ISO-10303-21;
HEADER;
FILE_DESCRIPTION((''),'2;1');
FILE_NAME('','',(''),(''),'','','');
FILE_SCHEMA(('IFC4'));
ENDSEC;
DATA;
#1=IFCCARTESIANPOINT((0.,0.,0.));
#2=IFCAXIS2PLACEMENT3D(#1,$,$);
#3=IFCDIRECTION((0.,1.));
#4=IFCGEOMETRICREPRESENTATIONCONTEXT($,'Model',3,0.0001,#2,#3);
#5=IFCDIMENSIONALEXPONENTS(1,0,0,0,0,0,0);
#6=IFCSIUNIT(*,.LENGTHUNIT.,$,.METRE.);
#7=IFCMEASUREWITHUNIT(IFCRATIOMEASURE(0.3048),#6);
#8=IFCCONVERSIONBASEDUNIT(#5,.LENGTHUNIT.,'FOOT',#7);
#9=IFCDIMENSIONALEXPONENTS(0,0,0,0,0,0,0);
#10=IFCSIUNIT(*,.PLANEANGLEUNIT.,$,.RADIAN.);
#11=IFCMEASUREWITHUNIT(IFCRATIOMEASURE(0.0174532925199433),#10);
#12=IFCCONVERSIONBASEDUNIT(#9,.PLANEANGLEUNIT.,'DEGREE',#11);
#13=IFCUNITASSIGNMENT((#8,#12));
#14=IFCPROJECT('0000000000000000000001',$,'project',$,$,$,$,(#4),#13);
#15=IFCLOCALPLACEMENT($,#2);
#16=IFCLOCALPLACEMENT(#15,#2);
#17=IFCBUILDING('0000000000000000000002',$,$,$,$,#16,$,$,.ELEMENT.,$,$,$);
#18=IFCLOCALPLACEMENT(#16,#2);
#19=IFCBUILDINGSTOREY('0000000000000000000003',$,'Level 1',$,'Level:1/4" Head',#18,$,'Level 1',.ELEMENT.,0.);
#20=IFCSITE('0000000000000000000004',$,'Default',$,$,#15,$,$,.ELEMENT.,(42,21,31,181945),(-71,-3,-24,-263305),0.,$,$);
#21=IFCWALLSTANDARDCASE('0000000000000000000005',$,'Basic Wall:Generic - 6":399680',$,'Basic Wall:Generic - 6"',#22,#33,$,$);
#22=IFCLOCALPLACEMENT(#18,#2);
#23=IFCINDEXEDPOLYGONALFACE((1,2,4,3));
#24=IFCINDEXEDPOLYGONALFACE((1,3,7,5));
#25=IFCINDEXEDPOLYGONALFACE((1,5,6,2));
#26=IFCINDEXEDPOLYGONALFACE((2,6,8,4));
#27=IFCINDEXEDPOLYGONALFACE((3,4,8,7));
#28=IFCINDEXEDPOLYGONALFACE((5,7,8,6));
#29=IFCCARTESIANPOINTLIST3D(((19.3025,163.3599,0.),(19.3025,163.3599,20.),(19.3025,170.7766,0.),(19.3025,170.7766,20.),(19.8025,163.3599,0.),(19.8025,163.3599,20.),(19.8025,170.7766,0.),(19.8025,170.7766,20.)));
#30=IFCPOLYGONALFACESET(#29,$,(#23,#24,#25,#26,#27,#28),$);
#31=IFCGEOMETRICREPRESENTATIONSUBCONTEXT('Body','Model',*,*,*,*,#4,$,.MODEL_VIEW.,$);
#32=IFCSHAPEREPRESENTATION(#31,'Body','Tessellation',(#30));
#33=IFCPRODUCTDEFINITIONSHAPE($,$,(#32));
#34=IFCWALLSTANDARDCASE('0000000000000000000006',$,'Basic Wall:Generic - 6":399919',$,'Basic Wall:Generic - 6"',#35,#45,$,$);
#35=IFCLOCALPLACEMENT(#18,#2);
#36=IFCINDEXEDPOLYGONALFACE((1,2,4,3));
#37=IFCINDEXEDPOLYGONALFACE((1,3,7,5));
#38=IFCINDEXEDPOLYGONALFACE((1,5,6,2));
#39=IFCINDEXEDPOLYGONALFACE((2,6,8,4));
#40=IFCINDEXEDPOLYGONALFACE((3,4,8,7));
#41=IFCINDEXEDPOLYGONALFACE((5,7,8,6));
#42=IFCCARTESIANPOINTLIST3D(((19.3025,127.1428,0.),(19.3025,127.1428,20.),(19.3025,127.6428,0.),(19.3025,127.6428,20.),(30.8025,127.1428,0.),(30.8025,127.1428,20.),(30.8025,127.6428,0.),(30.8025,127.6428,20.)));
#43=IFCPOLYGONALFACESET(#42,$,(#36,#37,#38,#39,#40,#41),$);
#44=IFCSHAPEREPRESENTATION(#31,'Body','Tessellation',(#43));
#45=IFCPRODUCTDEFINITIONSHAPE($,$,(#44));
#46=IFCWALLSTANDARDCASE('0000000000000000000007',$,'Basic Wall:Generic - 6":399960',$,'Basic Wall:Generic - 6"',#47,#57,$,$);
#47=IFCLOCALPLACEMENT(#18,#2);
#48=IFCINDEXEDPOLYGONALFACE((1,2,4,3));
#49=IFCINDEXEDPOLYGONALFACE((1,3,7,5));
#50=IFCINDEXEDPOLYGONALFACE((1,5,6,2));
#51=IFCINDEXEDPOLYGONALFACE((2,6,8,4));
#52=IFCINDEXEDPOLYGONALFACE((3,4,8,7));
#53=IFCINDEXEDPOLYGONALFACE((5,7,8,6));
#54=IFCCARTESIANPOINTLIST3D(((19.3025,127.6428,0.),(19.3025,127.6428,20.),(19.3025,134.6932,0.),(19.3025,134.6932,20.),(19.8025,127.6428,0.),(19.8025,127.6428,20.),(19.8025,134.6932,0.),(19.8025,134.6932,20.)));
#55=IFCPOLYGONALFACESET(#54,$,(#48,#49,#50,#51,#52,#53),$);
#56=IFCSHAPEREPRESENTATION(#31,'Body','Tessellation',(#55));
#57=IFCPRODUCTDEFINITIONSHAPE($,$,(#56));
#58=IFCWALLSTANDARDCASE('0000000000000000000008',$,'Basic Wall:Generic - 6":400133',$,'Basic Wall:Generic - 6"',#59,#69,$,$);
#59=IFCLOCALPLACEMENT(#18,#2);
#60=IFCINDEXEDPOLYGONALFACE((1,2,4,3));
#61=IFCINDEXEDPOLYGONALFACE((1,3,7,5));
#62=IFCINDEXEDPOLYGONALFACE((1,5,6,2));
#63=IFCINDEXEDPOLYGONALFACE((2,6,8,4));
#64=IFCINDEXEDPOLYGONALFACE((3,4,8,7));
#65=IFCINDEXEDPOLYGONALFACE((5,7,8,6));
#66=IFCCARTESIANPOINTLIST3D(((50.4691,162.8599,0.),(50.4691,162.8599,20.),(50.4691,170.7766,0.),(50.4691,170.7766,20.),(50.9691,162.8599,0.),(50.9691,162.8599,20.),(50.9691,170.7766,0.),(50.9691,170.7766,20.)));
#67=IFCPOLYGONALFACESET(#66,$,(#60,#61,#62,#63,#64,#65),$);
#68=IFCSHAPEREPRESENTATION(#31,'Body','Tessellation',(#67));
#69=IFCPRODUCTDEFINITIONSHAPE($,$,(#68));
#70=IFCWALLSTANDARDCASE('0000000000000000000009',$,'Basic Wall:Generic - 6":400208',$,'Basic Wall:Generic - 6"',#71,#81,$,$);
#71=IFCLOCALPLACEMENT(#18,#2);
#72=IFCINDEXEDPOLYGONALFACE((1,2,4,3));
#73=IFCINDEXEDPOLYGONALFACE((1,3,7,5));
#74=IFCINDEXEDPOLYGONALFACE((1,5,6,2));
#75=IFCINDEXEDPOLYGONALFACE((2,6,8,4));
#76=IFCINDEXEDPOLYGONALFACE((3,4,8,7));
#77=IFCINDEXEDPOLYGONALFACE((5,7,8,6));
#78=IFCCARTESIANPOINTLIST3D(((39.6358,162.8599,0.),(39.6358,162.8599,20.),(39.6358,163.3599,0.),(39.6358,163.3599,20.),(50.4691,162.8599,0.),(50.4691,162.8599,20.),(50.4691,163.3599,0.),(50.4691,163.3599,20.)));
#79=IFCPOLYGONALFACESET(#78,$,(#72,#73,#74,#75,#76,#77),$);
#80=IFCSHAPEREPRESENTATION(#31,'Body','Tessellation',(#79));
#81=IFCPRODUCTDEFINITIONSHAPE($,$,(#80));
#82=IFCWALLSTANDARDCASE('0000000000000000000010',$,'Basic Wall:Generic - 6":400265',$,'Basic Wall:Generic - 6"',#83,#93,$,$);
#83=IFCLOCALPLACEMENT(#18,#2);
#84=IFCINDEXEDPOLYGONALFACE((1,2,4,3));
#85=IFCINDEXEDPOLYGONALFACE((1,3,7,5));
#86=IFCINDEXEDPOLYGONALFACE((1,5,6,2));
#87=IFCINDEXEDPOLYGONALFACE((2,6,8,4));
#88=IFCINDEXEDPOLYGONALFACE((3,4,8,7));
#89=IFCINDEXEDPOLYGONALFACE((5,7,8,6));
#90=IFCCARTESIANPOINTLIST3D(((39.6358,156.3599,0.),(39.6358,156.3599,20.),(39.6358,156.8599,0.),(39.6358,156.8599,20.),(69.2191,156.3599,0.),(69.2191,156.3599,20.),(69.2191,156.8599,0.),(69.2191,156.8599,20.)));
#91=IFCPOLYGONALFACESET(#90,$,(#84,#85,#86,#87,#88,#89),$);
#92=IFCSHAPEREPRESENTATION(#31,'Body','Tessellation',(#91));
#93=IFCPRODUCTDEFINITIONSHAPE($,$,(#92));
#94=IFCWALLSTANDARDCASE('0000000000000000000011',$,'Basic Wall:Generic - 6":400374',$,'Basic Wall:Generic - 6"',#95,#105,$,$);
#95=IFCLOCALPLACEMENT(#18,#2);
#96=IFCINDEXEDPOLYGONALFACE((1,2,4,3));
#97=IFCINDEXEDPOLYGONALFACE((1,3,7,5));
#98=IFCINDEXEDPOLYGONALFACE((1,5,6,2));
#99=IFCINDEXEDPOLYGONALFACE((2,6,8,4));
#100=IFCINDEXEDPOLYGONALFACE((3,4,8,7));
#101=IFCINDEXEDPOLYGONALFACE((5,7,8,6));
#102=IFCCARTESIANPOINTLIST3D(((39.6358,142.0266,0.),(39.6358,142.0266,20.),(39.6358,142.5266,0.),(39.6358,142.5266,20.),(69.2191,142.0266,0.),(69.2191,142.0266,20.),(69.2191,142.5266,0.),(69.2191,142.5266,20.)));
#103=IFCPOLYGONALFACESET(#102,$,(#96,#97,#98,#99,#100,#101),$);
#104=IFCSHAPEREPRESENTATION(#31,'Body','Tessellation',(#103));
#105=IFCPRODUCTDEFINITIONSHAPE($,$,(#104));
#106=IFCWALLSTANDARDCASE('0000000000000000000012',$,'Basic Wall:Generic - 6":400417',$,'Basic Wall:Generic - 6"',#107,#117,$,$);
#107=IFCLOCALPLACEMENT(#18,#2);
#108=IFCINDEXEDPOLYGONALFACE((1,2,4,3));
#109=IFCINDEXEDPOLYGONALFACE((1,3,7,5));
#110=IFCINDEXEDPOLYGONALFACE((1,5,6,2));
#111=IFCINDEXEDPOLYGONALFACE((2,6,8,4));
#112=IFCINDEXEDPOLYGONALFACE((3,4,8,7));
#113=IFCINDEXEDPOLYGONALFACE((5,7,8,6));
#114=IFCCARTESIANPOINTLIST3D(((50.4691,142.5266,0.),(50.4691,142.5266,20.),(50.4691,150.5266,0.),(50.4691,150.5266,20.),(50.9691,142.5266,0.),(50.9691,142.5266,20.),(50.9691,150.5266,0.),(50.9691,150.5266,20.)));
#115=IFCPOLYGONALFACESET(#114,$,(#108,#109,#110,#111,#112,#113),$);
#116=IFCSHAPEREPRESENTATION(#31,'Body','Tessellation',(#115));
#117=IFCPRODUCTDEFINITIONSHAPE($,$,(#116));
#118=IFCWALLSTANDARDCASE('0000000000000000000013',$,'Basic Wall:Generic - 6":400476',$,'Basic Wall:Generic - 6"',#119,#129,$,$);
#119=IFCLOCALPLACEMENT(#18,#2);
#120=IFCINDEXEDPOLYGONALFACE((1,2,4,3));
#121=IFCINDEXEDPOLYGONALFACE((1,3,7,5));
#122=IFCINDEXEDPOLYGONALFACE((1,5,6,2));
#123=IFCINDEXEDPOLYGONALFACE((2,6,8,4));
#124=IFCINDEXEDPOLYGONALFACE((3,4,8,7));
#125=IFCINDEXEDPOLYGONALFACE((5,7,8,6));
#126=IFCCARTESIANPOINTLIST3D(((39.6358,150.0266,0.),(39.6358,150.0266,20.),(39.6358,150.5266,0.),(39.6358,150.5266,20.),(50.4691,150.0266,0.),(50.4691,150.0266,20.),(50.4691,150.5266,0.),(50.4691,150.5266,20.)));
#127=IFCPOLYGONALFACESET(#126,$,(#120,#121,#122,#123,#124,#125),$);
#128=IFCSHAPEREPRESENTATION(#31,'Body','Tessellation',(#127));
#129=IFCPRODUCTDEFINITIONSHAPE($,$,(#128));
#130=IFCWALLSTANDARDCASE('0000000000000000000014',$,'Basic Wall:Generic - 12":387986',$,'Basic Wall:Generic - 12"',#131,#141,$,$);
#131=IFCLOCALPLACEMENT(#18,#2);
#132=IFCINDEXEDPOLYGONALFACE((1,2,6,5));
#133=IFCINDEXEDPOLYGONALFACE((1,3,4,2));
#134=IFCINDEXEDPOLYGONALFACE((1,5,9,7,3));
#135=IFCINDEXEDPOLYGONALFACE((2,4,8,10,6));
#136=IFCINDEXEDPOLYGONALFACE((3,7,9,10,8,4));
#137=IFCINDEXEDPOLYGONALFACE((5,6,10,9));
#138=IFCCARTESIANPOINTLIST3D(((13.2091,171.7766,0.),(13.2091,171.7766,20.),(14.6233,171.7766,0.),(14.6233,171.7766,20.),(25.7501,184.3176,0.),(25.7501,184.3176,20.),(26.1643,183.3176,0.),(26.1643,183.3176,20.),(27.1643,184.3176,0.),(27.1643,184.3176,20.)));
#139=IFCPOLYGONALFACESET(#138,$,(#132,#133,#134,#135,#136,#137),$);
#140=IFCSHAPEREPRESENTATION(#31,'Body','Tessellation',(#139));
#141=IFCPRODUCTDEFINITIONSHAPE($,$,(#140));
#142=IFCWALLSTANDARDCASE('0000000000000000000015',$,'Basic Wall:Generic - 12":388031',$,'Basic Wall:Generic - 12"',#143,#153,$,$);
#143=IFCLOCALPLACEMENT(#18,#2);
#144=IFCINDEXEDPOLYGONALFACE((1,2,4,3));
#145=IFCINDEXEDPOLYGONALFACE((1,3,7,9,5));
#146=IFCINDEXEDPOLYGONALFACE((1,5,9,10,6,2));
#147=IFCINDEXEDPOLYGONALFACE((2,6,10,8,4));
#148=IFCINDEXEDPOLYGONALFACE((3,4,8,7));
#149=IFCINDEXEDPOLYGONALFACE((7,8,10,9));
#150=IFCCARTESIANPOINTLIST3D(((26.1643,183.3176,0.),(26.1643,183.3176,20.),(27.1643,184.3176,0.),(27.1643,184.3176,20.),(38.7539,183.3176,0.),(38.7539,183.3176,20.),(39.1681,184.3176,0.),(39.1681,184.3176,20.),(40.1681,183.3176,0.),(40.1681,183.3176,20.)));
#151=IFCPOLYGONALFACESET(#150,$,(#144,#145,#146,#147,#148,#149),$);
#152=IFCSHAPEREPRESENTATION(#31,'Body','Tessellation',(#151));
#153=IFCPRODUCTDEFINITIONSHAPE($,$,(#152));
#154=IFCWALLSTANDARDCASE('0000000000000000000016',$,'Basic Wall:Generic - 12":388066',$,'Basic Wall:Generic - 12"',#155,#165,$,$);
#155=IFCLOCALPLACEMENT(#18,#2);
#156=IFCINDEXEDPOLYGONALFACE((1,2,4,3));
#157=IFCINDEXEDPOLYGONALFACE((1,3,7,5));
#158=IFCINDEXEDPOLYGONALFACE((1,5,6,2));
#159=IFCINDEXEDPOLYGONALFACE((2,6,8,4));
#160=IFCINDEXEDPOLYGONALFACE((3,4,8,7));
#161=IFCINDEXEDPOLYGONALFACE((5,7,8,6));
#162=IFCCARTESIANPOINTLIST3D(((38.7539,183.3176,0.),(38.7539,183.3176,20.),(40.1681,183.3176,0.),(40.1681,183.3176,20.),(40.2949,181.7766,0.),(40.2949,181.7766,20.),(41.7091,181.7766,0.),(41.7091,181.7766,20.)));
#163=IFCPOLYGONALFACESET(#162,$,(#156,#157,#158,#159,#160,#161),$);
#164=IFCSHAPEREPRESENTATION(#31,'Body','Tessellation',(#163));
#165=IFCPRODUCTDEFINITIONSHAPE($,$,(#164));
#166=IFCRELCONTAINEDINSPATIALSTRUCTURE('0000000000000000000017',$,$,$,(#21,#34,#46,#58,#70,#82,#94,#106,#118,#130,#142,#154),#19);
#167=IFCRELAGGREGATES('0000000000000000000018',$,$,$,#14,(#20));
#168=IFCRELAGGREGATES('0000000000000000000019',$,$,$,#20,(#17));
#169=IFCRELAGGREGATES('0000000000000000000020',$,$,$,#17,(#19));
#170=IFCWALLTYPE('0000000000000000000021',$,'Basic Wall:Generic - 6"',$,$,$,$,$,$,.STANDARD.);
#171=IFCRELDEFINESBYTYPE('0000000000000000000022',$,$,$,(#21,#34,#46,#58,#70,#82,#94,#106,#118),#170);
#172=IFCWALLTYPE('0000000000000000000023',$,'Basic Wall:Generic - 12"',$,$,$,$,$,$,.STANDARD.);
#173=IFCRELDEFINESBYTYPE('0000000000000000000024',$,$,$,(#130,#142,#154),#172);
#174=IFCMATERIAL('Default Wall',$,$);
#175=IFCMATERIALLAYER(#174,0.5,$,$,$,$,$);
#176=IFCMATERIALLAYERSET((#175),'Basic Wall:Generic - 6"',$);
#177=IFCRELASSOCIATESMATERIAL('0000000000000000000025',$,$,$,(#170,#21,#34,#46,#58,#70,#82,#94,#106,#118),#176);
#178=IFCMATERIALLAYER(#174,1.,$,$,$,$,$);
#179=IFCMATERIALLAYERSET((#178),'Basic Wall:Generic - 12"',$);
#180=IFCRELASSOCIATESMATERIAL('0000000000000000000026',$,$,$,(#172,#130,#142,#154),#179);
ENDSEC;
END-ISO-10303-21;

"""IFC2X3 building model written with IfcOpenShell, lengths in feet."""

from ifc_helpers import new_model, entity, si_unit, converted_unit, direction, frame, frame_2d, origin, place, context, subcontext, project, spatial, polyline, rectangle, outline, extrude, material, layer, layer_set, layer_usage, type_object, element, save


model = new_model("IFC2X3")

# Units and contexts
model_context = context("Model", 3, precision=0.0001, world=origin(), true_north=direction((0.0, 1.0)))
body_context = subcontext(model_context, "Body", "Model", "MODEL_VIEW")
ifc_project = project(units=[converted_unit("LENGTHUNIT", "FOOT", entity("IfcRatioMeasure", 0.3048), si_unit("LENGTHUNIT", "METRE"), dimensions=[1, 0, 0, 0, 0, 0, 0]), converted_unit("PLANEANGLEUNIT", "DEGREE", entity("IfcRatioMeasure", 0.0174532925199433), si_unit("PLANEANGLEUNIT", "RADIAN"), dimensions=[0, 0, 0, 0, 0, 0, 0])], contexts=[model_context])

# Site, building, storey
site_placement = place(None, origin())
site = spatial("IfcSite", under=ifc_project, at=site_placement, Name="Default", CompositionType="ELEMENT", RefLatitude=(42, 21, 31, 181945), RefLongitude=(-71, -3, -24, -263305), RefElevation=0.0)
building_placement = place(site_placement, origin())
building = spatial("IfcBuilding", under=site, at=building_placement, CompositionType="ELEMENT")
storey_placement = place(building_placement, origin())
storey = spatial("IfcBuildingStorey", under=building, at=storey_placement, Name="Level 1", ObjectType="Level:1/4\" Head", LongName="Level 1", CompositionType="ELEMENT", Elevation=0.0)

# Walls
ifc_material = material(Name="Default Wall")
ifc_layer_1 = layer(ifc_material, 0.5)
ifc_layer_set_1 = layer_set([ifc_layer_1], Name="Basic Wall:Generic - 6\"")
wall_type_1 = type_object("IfcWallType", Name="Basic Wall:Generic - 6\"", PredefinedType="STANDARD", material=ifc_layer_set_1)
ifc_layer_usage_1 = layer_usage(ifc_layer_set_1, "AXIS2", "NEGATIVE", 0.25)
wall_1_placement = place(storey_placement, frame((19.5525, 163.3599, 0.0), z_axis=(0.0, 0.0, 1.0), x_axis=(0.0, 1.0, 0.0)))
element("IfcWallStandardCase", 1, at=wall_1_placement, inside=storey, type_object=wall_type_1, material=ifc_layer_usage_1, Name="Basic Wall:Generic - 6\":399680", ObjectType="Basic Wall:Generic - 6\"", context=body_context, shape_type="SweptSolid", body=[
    extrude(rectangle(XDim=7.4167, YDim=0.5, at=frame_2d((3.7083, 0.0), x_axis=(-1.0, 0.0))), origin(), (0.0, 0.0, 1.0), 20.0),
])
ifc_layer_usage_2 = layer_usage(ifc_layer_set_1, "AXIS2", "NEGATIVE", 0.25)
wall_2_placement = place(storey_placement, frame((30.8025, 127.3928, 0.0), z_axis=(0.0, 0.0, 1.0), x_axis=(-1.0, 0.0, 0.0)))
element("IfcWallStandardCase", 2, at=wall_2_placement, inside=storey, type_object=wall_type_1, material=ifc_layer_usage_2, Name="Basic Wall:Generic - 6\":399919", ObjectType="Basic Wall:Generic - 6\"", context=body_context, shape_type="SweptSolid", body=[
    extrude(rectangle(XDim=11.5, YDim=0.5, at=frame_2d((5.75, 0.0), x_axis=(-1.0, 0.0))), origin(), (0.0, 0.0, 1.0), 20.0),
])
ifc_layer_usage_3 = layer_usage(ifc_layer_set_1, "AXIS2", "NEGATIVE", 0.25)
wall_3_placement = place(storey_placement, frame((19.5525, 127.6428, 0.0), z_axis=(0.0, 0.0, 1.0), x_axis=(0.0, 1.0, 0.0)))
element("IfcWallStandardCase", 3, at=wall_3_placement, inside=storey, type_object=wall_type_1, material=ifc_layer_usage_3, Name="Basic Wall:Generic - 6\":399960", ObjectType="Basic Wall:Generic - 6\"", context=body_context, shape_type="SweptSolid", body=[
    extrude(rectangle(XDim=7.0504, YDim=0.5, at=frame_2d((3.5252, 0.0), x_axis=(-1.0, 0.0))), origin(), (0.0, 0.0, 1.0), 20.0),
])
ifc_layer_usage_4 = layer_usage(ifc_layer_set_1, "AXIS2", "NEGATIVE", 0.25)
wall_4_placement = place(storey_placement, frame((50.7191, 170.7766, 0.0), z_axis=(0.0, 0.0, 1.0), x_axis=(0.0, -1.0, 0.0)))
element("IfcWallStandardCase", 4, at=wall_4_placement, inside=storey, type_object=wall_type_1, material=ifc_layer_usage_4, Name="Basic Wall:Generic - 6\":400133", ObjectType="Basic Wall:Generic - 6\"", context=body_context, shape_type="SweptSolid", body=[
    extrude(rectangle(XDim=7.9167, YDim=0.5, at=frame_2d((3.9583, 0.0), x_axis=(-1.0, 0.0))), origin(), (0.0, 0.0, 1.0), 20.0),
])
ifc_layer_usage_5 = layer_usage(ifc_layer_set_1, "AXIS2", "NEGATIVE", 0.25)
wall_5_placement = place(storey_placement, frame((50.4691, 163.1099, 0.0), z_axis=(0.0, 0.0, 1.0), x_axis=(-1.0, 0.0, 0.0)))
element("IfcWallStandardCase", 5, at=wall_5_placement, inside=storey, type_object=wall_type_1, material=ifc_layer_usage_5, Name="Basic Wall:Generic - 6\":400208", ObjectType="Basic Wall:Generic - 6\"", context=body_context, shape_type="SweptSolid", body=[
    extrude(rectangle(XDim=10.8333, YDim=0.5, at=frame_2d((5.4167, 0.0), x_axis=(-1.0, 0.0))), origin(), (0.0, 0.0, 1.0), 20.0),
])
ifc_layer_usage_6 = layer_usage(ifc_layer_set_1, "AXIS2", "NEGATIVE", 0.25)
wall_6_placement = place(storey_placement, frame((39.6358, 156.6099, 0.0)))
element("IfcWallStandardCase", 6, at=wall_6_placement, inside=storey, type_object=wall_type_1, material=ifc_layer_usage_6, Name="Basic Wall:Generic - 6\":400265", ObjectType="Basic Wall:Generic - 6\"", context=body_context, shape_type="SweptSolid", body=[
    extrude(rectangle(XDim=29.5833, YDim=0.5, at=frame_2d((14.7917, 0.0), x_axis=(-1.0, 0.0))), origin(), (0.0, 0.0, 1.0), 20.0),
])
ifc_layer_usage_7 = layer_usage(ifc_layer_set_1, "AXIS2", "NEGATIVE", 0.25)
wall_7_placement = place(storey_placement, frame((69.2191, 142.2766, 0.0), z_axis=(0.0, 0.0, 1.0), x_axis=(-1.0, 0.0, 0.0)))
element("IfcWallStandardCase", 7, at=wall_7_placement, inside=storey, type_object=wall_type_1, material=ifc_layer_usage_7, Name="Basic Wall:Generic - 6\":400374", ObjectType="Basic Wall:Generic - 6\"", context=body_context, shape_type="SweptSolid", body=[
    extrude(rectangle(XDim=29.5833, YDim=0.5, at=frame_2d((14.7917, 0.0), x_axis=(-1.0, 0.0))), origin(), (0.0, 0.0, 1.0), 20.0),
])
ifc_layer_usage_8 = layer_usage(ifc_layer_set_1, "AXIS2", "NEGATIVE", 0.25)
wall_8_placement = place(storey_placement, frame((50.7191, 142.5266, 0.0), z_axis=(0.0, 0.0, 1.0), x_axis=(0.0, 1.0, 0.0)))
element("IfcWallStandardCase", 8, at=wall_8_placement, inside=storey, type_object=wall_type_1, material=ifc_layer_usage_8, Name="Basic Wall:Generic - 6\":400417", ObjectType="Basic Wall:Generic - 6\"", context=body_context, shape_type="SweptSolid", body=[
    extrude(rectangle(XDim=8.0, YDim=0.5, at=frame_2d((4.0, 0.0), x_axis=(-1.0, 0.0))), origin(), (0.0, 0.0, 1.0), 20.0),
])
ifc_layer_usage_9 = layer_usage(ifc_layer_set_1, "AXIS2", "NEGATIVE", 0.25)
wall_9_placement = place(storey_placement, frame((50.4691, 150.2766, 0.0), z_axis=(0.0, 0.0, 1.0), x_axis=(-1.0, 0.0, 0.0)))
element("IfcWallStandardCase", 9, at=wall_9_placement, inside=storey, type_object=wall_type_1, material=ifc_layer_usage_9, Name="Basic Wall:Generic - 6\":400476", ObjectType="Basic Wall:Generic - 6\"", context=body_context, shape_type="SweptSolid", body=[
    extrude(rectangle(XDim=10.8333, YDim=0.5, at=frame_2d((5.4167, 0.0), x_axis=(-1.0, 0.0))), origin(), (0.0, 0.0, 1.0), 20.0),
])
ifc_layer_2 = layer(ifc_material, 1.0)
ifc_layer_set_2 = layer_set([ifc_layer_2], Name="Basic Wall:Generic - 12\"")
ifc_layer_usage_10 = layer_usage(ifc_layer_set_2, "AXIS2", "NEGATIVE", 0.5)
wall_type_2 = type_object("IfcWallType", Name="Basic Wall:Generic - 12\"", PredefinedType="STANDARD", material=ifc_layer_set_2)
wall_10_placement = place(storey_placement, frame((13.5626, 171.423, 0.0), z_axis=(0.0, 0.0, 1.0), x_axis=(0.707107, 0.707107, 0.0)))
element("IfcWallStandardCase", 10, at=wall_10_placement, inside=storey, type_object=wall_type_2, material=ifc_layer_usage_10, Name="Basic Wall:Generic - 12\":387986", ObjectType="Basic Wall:Generic - 12\"", context=body_context, shape_type="SweptSolid", body=[
    extrude(outline(polyline([(18.7357, -0.5), (17.7357, 0.5), (0.0, 0.5), (1.0, -0.5), (17.3215, -0.5), (18.7357, -0.5)])), origin(), (0.0, 0.0, 1.0), 20.0),
])
ifc_layer_usage_11 = layer_usage(ifc_layer_set_2, "AXIS2", "NEGATIVE", 0.5)
wall_11_placement = place(storey_placement, frame((26.1643, 183.8176, 0.0)))
element("IfcWallStandardCase", 11, at=wall_11_placement, inside=storey, type_object=wall_type_2, material=ifc_layer_usage_11, Name="Basic Wall:Generic - 12\":388031", ObjectType="Basic Wall:Generic - 12\"", context=body_context, shape_type="SweptSolid", body=[
    extrude(outline(polyline([(14.0037, -0.5), (13.0037, 0.5), (1.0, 0.5), (0.0, -0.5), (12.5895, -0.5), (14.0037, -0.5)])), origin(), (0.0, 0.0, 1.0), 20.0),
])
ifc_layer_usage_12 = layer_usage(ifc_layer_set_2, "AXIS2", "NEGATIVE", 0.5)
wall_12_placement = place(storey_placement, frame((39.1074, 183.6712, 0.0), z_axis=(0.0, 0.0, 1.0), x_axis=(0.707107, -0.707107, 0.0)))
element("IfcWallStandardCase", 12, at=wall_12_placement, inside=storey, type_object=wall_type_2, material=ifc_layer_usage_12, Name="Basic Wall:Generic - 12\":388066", ObjectType="Basic Wall:Generic - 12\"", context=body_context, shape_type="SweptSolid", body=[
    extrude(outline(polyline([(2.1794, -0.5), (3.1794, 0.5), (1.0, 0.5), (0.0, -0.5), (2.1794, -0.5)])), origin(), (0.0, 0.0, 1.0), 20.0),
])

save(model, "model.ifc")
